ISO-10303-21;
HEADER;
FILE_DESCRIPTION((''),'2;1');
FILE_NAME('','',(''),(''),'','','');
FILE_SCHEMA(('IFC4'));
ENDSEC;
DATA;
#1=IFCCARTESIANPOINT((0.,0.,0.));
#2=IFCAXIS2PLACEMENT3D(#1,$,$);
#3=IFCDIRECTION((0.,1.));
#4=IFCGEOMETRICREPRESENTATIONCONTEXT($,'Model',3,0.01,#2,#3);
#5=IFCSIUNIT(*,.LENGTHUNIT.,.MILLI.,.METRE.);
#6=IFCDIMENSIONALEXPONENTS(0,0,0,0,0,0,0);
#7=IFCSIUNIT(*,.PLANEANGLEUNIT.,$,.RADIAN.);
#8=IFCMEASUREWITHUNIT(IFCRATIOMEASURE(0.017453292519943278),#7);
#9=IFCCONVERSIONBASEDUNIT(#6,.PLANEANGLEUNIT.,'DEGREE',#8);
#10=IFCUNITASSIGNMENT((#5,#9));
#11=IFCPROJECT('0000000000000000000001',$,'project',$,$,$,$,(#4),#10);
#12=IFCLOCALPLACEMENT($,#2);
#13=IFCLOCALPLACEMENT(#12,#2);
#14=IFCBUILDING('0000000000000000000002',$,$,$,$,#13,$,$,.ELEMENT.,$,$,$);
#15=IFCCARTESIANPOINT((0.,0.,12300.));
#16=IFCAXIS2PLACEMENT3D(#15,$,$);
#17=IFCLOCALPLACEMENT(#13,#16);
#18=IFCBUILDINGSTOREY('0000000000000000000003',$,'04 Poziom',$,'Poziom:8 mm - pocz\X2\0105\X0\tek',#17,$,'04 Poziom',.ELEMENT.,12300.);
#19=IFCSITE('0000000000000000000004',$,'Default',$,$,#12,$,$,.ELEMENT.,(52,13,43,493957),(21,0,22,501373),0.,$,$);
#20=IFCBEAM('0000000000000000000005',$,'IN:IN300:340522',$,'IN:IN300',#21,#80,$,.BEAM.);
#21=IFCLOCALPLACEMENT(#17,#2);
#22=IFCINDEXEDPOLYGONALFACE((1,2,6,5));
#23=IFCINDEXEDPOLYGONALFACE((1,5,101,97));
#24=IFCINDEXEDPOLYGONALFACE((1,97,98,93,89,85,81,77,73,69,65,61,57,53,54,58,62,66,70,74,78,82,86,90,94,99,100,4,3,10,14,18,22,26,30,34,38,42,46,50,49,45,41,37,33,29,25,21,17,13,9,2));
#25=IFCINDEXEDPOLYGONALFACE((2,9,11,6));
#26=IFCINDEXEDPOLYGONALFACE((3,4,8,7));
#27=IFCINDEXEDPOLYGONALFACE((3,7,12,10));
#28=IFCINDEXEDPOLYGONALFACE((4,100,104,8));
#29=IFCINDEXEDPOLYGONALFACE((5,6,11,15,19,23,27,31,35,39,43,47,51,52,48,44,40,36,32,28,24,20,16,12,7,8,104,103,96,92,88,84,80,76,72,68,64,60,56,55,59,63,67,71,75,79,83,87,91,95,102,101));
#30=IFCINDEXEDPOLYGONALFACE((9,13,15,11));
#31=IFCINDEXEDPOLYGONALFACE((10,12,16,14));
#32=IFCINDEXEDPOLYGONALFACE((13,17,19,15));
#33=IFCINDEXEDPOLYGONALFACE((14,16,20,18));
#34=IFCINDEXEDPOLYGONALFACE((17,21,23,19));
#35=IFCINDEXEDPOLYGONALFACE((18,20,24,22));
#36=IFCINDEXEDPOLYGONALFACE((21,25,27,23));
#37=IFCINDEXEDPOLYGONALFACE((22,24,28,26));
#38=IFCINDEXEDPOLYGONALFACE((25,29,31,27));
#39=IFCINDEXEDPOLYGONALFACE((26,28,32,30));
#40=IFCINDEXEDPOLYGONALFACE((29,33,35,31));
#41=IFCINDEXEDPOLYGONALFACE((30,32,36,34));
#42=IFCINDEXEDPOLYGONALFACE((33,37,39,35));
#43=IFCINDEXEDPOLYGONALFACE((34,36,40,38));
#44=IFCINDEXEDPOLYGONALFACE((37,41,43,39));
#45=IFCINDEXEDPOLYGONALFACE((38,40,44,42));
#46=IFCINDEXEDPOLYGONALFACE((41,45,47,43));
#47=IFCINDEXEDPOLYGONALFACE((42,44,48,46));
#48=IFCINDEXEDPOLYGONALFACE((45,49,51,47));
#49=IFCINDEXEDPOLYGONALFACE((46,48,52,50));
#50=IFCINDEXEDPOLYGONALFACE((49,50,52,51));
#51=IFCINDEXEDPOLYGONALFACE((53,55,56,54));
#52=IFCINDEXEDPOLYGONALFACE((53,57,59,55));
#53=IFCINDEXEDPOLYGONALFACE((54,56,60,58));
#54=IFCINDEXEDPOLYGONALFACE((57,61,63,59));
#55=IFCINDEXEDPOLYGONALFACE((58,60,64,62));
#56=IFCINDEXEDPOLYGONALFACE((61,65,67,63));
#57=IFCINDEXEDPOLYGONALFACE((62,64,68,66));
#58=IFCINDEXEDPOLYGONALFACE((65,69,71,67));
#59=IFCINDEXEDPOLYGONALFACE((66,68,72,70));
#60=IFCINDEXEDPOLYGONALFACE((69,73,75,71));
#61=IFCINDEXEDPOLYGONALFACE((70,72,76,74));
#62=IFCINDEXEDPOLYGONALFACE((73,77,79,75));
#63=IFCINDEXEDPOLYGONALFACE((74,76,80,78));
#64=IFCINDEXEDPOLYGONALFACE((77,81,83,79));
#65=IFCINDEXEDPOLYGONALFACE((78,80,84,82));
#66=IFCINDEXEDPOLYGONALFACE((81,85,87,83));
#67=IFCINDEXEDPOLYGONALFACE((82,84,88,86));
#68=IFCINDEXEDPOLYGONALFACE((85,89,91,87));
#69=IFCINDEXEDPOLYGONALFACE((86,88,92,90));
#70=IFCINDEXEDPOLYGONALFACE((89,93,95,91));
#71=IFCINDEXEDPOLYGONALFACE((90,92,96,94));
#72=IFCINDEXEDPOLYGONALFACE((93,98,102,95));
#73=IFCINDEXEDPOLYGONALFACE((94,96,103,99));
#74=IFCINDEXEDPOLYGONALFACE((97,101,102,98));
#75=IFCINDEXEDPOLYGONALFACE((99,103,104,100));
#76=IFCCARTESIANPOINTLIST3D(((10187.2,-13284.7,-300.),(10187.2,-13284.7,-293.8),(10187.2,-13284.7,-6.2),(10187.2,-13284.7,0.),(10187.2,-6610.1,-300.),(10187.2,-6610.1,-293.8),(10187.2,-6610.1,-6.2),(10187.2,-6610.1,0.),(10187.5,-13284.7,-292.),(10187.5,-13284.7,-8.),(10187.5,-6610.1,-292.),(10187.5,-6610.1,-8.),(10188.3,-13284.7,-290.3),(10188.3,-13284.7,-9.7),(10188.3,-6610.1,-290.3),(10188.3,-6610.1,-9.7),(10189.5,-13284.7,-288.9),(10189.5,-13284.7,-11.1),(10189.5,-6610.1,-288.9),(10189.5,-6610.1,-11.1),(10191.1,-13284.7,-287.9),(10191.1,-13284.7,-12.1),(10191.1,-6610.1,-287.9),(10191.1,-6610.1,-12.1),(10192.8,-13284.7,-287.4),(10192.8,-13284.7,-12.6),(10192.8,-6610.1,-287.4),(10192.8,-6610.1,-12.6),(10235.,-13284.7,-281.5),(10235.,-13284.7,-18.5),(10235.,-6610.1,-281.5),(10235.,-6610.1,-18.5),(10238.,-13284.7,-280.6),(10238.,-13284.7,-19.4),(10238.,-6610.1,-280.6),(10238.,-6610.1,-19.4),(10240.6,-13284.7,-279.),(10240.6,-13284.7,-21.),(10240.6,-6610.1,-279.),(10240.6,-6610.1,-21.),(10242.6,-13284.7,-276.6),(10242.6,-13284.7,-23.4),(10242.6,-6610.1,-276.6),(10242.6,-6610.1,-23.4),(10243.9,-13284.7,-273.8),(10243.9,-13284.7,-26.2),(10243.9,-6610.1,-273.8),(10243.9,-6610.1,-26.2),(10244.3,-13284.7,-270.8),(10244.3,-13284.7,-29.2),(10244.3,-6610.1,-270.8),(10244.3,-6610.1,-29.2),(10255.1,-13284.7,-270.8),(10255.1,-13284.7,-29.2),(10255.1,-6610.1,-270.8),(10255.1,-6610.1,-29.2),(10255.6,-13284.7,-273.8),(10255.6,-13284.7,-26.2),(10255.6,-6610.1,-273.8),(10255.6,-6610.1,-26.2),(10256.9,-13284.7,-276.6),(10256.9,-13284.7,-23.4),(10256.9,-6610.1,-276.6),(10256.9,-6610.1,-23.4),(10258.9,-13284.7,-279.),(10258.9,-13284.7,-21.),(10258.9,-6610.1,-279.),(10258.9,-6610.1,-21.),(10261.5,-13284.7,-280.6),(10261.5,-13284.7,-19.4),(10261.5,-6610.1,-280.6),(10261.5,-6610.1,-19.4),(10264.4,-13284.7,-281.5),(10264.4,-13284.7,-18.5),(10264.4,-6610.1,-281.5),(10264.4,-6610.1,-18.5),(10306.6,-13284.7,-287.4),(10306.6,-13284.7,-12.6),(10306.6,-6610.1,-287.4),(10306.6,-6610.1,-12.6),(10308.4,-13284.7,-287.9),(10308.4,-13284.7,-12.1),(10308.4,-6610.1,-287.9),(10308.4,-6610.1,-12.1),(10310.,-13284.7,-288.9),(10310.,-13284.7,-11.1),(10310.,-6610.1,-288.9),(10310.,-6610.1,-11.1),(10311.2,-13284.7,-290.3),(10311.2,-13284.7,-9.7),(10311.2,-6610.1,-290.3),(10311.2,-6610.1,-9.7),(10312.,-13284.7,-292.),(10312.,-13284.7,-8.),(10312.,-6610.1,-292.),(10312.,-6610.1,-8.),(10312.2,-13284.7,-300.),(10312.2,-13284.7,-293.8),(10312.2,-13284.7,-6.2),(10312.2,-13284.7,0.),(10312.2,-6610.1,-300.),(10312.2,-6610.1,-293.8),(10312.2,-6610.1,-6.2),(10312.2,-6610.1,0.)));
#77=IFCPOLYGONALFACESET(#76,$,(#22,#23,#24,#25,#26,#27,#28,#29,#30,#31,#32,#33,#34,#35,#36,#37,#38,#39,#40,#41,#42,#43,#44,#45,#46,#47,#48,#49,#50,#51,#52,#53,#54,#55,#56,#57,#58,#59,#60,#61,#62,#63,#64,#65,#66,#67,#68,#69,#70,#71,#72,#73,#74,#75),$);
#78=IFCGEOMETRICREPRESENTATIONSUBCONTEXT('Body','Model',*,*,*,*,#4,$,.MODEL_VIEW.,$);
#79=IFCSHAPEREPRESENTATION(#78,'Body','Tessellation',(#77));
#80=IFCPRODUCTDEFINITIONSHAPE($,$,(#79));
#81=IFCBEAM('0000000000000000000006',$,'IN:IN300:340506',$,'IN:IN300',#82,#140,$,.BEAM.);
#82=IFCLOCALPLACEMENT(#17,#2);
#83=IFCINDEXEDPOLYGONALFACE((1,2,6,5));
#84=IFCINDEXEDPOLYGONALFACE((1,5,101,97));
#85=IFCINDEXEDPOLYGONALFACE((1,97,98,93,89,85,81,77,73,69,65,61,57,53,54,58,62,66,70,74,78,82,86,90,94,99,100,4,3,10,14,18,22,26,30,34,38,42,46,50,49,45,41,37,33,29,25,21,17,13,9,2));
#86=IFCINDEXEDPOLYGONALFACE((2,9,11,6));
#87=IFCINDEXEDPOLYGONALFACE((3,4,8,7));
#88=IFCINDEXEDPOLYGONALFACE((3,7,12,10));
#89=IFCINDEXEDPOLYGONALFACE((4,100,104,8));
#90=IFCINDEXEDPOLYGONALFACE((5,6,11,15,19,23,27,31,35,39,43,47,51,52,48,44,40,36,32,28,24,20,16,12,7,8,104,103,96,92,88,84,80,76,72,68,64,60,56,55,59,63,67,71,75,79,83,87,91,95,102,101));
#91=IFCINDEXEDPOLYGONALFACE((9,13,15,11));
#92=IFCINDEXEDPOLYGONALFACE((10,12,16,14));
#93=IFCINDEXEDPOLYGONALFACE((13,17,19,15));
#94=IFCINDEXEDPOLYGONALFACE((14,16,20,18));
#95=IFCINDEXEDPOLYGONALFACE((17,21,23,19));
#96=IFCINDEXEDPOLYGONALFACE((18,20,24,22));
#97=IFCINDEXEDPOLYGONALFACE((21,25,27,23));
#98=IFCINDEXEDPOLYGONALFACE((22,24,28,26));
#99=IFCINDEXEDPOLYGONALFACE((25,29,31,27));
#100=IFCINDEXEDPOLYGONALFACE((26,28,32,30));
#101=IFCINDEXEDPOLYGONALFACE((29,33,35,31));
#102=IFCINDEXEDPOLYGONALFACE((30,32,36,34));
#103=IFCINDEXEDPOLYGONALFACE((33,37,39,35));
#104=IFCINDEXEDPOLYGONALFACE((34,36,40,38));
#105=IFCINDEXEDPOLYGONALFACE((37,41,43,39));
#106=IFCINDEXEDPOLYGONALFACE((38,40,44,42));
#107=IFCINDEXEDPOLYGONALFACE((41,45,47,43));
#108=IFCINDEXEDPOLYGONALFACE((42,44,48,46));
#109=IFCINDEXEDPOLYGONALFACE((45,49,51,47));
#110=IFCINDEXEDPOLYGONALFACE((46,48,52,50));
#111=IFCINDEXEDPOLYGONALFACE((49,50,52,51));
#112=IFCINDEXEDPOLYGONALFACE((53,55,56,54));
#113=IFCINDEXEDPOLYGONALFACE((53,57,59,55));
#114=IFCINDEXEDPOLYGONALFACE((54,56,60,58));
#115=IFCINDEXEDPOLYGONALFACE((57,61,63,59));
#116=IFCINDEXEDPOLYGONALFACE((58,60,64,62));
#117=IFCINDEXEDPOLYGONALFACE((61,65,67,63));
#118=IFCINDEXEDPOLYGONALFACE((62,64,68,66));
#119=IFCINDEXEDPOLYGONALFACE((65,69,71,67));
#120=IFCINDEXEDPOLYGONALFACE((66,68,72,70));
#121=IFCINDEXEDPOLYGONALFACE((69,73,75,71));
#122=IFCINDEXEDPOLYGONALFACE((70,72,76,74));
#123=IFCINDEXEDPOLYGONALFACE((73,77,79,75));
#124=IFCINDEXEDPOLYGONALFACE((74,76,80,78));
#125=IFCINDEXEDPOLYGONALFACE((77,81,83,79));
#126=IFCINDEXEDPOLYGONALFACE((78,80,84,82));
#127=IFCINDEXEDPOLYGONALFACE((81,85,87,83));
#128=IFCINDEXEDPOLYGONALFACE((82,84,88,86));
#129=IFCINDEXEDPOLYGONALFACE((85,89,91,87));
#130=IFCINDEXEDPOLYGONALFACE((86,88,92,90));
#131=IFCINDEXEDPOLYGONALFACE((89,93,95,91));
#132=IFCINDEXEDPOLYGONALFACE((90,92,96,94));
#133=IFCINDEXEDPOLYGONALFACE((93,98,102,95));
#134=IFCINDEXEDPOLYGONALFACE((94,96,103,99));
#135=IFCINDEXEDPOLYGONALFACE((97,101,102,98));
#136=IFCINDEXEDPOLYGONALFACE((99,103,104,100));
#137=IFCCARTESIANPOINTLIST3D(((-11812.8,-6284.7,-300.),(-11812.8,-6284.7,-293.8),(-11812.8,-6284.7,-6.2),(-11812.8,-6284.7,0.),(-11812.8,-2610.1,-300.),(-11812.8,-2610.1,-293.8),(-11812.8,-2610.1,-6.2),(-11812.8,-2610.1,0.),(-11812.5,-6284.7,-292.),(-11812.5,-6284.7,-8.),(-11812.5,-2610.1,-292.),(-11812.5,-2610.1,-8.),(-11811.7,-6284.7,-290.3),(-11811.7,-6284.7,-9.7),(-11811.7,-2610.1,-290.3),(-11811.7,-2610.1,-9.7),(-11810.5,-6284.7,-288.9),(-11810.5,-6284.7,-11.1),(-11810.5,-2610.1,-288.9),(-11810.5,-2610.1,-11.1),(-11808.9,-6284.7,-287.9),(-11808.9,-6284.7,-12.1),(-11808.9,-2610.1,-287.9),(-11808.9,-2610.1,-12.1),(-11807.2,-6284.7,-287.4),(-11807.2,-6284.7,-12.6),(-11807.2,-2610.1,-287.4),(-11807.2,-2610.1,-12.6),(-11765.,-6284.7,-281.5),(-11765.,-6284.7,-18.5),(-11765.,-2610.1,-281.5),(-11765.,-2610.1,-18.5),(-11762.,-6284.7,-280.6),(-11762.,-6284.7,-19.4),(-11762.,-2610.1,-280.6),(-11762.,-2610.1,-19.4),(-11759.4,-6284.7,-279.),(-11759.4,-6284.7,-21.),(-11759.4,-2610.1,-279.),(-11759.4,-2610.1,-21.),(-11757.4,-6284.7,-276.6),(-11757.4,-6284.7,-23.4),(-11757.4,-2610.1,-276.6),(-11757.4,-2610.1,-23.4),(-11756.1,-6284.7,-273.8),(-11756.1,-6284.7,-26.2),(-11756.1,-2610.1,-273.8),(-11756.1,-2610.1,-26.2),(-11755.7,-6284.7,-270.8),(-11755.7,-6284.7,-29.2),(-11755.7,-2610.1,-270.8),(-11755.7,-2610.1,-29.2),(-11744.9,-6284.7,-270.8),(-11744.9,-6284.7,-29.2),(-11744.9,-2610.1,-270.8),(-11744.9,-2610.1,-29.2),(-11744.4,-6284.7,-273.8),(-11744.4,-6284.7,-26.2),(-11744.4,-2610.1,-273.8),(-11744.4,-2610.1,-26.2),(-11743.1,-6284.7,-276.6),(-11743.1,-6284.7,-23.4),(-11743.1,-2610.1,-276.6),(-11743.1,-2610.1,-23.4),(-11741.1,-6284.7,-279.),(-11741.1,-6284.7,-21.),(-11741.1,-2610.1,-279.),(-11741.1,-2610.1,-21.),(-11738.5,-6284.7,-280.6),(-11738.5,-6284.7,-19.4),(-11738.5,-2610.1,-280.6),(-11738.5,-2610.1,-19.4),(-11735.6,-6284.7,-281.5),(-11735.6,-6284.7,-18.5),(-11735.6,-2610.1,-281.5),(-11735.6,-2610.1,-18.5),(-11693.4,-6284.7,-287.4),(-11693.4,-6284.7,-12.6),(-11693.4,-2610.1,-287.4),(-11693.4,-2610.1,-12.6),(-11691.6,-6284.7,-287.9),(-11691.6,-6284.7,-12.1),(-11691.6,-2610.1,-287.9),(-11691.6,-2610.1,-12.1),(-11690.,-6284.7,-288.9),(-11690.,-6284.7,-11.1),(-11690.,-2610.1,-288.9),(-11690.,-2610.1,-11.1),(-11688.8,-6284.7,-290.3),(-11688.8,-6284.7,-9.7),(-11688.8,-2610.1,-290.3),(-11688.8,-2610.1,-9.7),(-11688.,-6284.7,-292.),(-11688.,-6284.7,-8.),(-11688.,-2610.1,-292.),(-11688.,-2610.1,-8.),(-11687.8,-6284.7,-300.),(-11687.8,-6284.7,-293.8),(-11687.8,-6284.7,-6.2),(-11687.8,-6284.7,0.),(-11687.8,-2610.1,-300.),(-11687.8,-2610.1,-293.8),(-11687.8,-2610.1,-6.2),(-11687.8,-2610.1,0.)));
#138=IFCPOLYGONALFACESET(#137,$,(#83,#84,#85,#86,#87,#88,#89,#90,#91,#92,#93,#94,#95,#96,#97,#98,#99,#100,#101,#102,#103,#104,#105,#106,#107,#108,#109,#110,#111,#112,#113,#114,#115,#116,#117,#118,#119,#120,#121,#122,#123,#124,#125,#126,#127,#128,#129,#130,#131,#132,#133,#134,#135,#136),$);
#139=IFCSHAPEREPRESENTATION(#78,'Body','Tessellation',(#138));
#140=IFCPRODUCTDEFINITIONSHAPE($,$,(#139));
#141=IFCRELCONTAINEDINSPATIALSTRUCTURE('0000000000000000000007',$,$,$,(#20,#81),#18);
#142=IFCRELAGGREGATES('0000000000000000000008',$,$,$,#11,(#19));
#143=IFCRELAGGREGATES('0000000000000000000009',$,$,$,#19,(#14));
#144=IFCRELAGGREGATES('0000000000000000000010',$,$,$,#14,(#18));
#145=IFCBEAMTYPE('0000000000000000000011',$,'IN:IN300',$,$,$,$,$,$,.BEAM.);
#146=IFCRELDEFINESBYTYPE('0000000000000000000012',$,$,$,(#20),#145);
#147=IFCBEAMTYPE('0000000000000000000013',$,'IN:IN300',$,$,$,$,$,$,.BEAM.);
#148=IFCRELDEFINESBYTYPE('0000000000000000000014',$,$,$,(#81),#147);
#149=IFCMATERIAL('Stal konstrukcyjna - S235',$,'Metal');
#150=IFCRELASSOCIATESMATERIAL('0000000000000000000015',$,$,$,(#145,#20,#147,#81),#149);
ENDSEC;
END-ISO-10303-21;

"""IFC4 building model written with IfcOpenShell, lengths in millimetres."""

from ifc_helpers import new_model, entity, si_unit, converted_unit, direction, frame, origin, place, context, subcontext, project, spatial, line, arc, indexed_curve, outline, extrude, source, transform, mapped, material, type_object, type_shapes, element, save


model = new_model("IFC4")

# Units and contexts
model_context = context("Model", 3, precision=0.01, world=origin(), true_north=direction((0.0, 1.0)))
body_context = subcontext(model_context, "Body", "Model", "MODEL_VIEW")
ifc_project = project(units=[si_unit("LENGTHUNIT", "METRE", prefix="MILLI"), converted_unit("PLANEANGLEUNIT", "DEGREE", entity("IfcRatioMeasure", 0.017453292519943278), si_unit("PLANEANGLEUNIT", "RADIAN"), dimensions=[0, 0, 0, 0, 0, 0, 0])], contexts=[model_context])

# Site, building, storey
site_placement = place(None, origin())
site = spatial("IfcSite", under=ifc_project, at=site_placement, Name="Default", CompositionType="ELEMENT", RefLatitude=(52, 13, 43, 493957), RefLongitude=(21, 0, 22, 501373), RefElevation=0.0)
building_placement = place(site_placement, origin())
building = spatial("IfcBuilding", under=site, at=building_placement, CompositionType="ELEMENT")
storey_placement = place(building_placement, frame((0.0, 0.0, 12300.0)))
storey = spatial("IfcBuildingStorey", under=building, at=storey_placement, Name="04 Poziom", ObjectType="Poziom:8 mm - początek", LongName="04 Poziom", CompositionType="ELEMENT", Elevation=12300.0)

# Shared definitions
ifc_material = material(Name="Stal konstrukcyjna - S235", Category="Metal")

# Beams
beam_type_1 = type_object("IfcBeamType", Name="IN:IN300", PredefinedType="BEAM", material=ifc_material)
shared_shape_1 = source(origin(), body_context, "Body", "SweptSolid", [
    extrude(outline(indexed_curve([(143.8, -62.5), (150.0, -62.5), (150.0, 62.5), (143.8, 62.5), (139.6, 60.9), (137.4, 56.9), (131.5, 14.7), (127.9, 8.1), (120.8, 5.4), (-120.8, 5.4), (-127.9, 8.1), (-131.5, 14.7), (-137.4, 56.9), (-139.6, 60.9), (-143.8, 62.5), (-150.0, 62.5), (-150.0, -62.5), (-143.8, -62.5), (-139.6, -60.9), (-137.4, -56.9), (-131.5, -14.7), (-127.9, -8.1), (-120.8, -5.4), (120.8, -5.4), (127.9, -8.1), (131.5, -14.7), (137.4, -56.9), (139.6, -60.9)], segments=[line(1, 2, 3, 4), arc(4, 5, 6), line(6, 7), arc(7, 8, 9), line(9, 10), arc(10, 11, 12), line(12, 13), arc(13, 14, 15), line(15, 16, 17, 18), arc(18, 19, 20), line(20, 21), arc(21, 22, 23), line(23, 24), arc(24, 25, 26), line(26, 27), arc(27, 28, 1)], self_intersect=False)), frame((-3337.3, 0.0, 0.0), z_axis=(1.0, 0.0, 0.0), x_axis=(0.0, 0.0, -1.0)), (0.0, 0.0, 1.0), 6674.6),
])
type_shapes(beam_type_1, [shared_shape_1])
for number, where, z_axis, x_axis, name in (
    (1, (10249.7, -9947.4, -150.0), (0.0, 0.0, 1.0), (0.0, -1.0, 0.0), "IN:IN300:340522"),
):
    element("IfcBeam", number, at=place(storey_placement, frame(where, z_axis=z_axis, x_axis=x_axis)), inside=storey, type_object=beam_type_1, material=ifc_material, Name=name, ObjectType="IN:IN300", PredefinedType="BEAM", context=body_context, shape_type="MappedRepresentation", body=[
        mapped(shared_shape_1, transform((0.0, 0.0, 0.0), scale=1.0)),
    ])
beam_type_2 = type_object("IfcBeamType", Name="IN:IN300", PredefinedType="BEAM", material=ifc_material)
shared_shape_2 = source(origin(), body_context, "Body", "SweptSolid", [
    extrude(outline(indexed_curve([(143.8, -62.5), (150.0, -62.5), (150.0, 62.5), (143.8, 62.5), (139.6, 60.9), (137.4, 56.9), (131.5, 14.7), (127.9, 8.1), (120.8, 5.4), (-120.8, 5.4), (-127.9, 8.1), (-131.5, 14.7), (-137.4, 56.9), (-139.6, 60.9), (-143.8, 62.5), (-150.0, 62.5), (-150.0, -62.5), (-143.8, -62.5), (-139.6, -60.9), (-137.4, -56.9), (-131.5, -14.7), (-127.9, -8.1), (-120.8, -5.4), (120.8, -5.4), (127.9, -8.1), (131.5, -14.7), (137.4, -56.9), (139.6, -60.9)], segments=[line(1, 2, 3, 4), arc(4, 5, 6), line(6, 7), arc(7, 8, 9), line(9, 10), arc(10, 11, 12), line(12, 13), arc(13, 14, 15), line(15, 16, 17, 18), arc(18, 19, 20), line(20, 21), arc(21, 22, 23), line(23, 24), arc(24, 25, 26), line(26, 27), arc(27, 28, 1)], self_intersect=False)), frame((-1837.3, 0.0, 0.0), z_axis=(1.0, 0.0, 0.0), x_axis=(0.0, 0.0, -1.0)), (0.0, 0.0, 1.0), 3674.6),
])
type_shapes(beam_type_2, [shared_shape_2])
for number, where, z_axis, x_axis, name in (
    (2, (-11750.3, -4447.4, -150.0), (0.0, 0.0, 1.0), (0.0, -1.0, 0.0), "IN:IN300:340506"),
):
    element("IfcBeam", number, at=place(storey_placement, frame(where, z_axis=z_axis, x_axis=x_axis)), inside=storey, type_object=beam_type_2, material=ifc_material, Name=name, ObjectType="IN:IN300", PredefinedType="BEAM", context=body_context, shape_type="MappedRepresentation", body=[
        mapped(shared_shape_2, transform((0.0, 0.0, 0.0), scale=1.0)),
    ])

save(model, "model.ifc")
